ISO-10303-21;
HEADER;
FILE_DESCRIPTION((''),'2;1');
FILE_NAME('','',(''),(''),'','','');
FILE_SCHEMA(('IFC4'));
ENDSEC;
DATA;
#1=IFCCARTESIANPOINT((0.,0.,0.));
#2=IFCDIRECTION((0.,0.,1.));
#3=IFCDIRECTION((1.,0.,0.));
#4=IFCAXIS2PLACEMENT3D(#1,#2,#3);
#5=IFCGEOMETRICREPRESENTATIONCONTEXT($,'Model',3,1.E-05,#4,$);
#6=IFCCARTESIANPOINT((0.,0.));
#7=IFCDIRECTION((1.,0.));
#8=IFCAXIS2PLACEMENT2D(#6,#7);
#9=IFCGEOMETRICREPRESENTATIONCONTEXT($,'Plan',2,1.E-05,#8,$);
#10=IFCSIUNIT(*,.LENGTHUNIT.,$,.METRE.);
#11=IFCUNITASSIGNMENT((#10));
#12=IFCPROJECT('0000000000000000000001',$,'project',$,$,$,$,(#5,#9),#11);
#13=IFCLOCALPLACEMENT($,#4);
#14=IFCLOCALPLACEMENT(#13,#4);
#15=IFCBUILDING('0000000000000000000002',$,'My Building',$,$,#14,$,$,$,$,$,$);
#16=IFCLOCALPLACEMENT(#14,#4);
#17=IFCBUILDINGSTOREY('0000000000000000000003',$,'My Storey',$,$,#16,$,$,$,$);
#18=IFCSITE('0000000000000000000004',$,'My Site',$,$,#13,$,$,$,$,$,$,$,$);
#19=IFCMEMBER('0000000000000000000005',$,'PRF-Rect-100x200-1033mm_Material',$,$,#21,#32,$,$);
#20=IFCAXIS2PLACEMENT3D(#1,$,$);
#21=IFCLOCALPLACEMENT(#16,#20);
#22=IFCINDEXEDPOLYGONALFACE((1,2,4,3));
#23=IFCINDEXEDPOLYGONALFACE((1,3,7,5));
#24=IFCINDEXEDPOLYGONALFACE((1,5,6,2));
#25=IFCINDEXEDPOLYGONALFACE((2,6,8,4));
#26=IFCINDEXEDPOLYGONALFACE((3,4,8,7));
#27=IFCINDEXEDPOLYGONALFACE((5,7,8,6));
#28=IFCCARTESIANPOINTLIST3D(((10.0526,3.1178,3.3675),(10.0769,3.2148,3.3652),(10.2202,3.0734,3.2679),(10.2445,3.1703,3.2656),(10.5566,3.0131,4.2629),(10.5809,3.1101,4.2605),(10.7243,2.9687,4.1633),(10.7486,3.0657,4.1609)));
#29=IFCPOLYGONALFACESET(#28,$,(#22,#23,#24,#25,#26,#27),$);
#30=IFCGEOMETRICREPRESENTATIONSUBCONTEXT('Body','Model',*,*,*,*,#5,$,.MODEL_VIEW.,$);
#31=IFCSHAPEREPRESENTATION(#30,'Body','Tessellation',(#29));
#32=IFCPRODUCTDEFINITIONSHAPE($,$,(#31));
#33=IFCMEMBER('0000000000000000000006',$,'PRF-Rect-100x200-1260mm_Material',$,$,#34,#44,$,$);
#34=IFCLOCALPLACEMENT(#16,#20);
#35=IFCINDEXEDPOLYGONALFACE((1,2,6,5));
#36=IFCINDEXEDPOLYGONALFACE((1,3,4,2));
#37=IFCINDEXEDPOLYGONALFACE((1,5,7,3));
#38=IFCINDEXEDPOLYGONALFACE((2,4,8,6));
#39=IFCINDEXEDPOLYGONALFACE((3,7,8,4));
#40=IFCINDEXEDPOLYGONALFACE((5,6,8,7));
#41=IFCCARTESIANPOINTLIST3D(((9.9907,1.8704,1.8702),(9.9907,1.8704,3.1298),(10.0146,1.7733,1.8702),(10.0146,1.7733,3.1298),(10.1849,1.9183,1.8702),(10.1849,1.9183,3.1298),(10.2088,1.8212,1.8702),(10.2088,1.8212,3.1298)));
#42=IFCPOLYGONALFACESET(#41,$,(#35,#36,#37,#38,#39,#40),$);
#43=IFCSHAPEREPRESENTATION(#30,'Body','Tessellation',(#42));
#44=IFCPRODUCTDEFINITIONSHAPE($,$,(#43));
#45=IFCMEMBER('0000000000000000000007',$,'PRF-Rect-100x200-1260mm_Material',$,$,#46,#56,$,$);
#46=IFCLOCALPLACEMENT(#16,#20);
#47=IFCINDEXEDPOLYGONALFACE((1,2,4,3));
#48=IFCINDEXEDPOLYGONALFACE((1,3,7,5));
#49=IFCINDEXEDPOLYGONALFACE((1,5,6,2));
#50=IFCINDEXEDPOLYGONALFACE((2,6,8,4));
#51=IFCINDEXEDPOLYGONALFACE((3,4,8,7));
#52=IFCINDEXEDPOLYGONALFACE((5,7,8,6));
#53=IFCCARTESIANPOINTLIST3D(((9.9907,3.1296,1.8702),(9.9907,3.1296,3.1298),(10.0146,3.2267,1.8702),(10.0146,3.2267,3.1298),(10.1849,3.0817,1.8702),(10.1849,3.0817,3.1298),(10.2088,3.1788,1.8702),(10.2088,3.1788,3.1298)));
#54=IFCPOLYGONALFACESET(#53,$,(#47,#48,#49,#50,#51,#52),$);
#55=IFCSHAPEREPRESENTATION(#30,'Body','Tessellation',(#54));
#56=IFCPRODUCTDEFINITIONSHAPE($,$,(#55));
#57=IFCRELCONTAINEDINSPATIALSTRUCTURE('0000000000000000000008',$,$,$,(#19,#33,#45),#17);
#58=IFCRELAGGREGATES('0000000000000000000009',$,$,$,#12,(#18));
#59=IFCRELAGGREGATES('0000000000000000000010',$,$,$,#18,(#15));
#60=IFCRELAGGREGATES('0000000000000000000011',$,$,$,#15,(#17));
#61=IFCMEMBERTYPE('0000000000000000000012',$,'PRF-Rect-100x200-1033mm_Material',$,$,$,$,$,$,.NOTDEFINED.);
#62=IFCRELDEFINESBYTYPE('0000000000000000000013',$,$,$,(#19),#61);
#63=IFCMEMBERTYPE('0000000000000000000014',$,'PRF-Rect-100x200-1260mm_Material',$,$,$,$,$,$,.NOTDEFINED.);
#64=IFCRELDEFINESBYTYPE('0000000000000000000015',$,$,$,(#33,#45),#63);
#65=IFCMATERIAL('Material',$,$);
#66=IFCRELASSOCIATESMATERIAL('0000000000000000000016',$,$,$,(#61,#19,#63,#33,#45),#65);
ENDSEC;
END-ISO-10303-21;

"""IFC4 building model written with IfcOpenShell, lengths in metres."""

from ifc_helpers import new_model, si_unit, frame, origin, origin_with_axes, origin_2d_with_axis, place, context, subcontext, project, spatial, rectangle, extrude, material, material_profile, profile_set, profile_usage, type_object, element, save


model = new_model("IFC4")

# Units and contexts
model_context = context("Model", 3, precision=1e-05, world=origin_with_axes())
plan_context = context("Plan", 2, precision=1e-05, world=origin_2d_with_axis())
body_context = subcontext(model_context, "Body", "Model", "MODEL_VIEW")
ifc_project = project(units=[si_unit("LENGTHUNIT", "METRE")], contexts=[model_context, plan_context])

# Site, building, storey
site_placement = place(None, origin_with_axes())
site = spatial("IfcSite", under=ifc_project, at=site_placement, Name="My Site")
building_placement = place(site_placement, origin_with_axes())
building = spatial("IfcBuilding", under=site, at=building_placement, Name="My Building")
storey_placement = place(building_placement, origin_with_axes())
storey = spatial("IfcBuildingStorey", under=building, at=storey_placement, Name="My Storey")

# Members
ifc_material_1 = material(Name="Material")
ifc_material_profile_1 = material_profile(ifc_material_1, rectangle(XDim=0.1, YDim=0.2))
ifc_profile_set_1 = profile_set([ifc_material_profile_1], Name="PRF-Rect-100x200-1033mm_Material")
member_type_1 = type_object("IfcMemberType", Name="PRF-Rect-100x200-1033mm_Material", PredefinedType="NOTDEFINED", material=ifc_profile_set_1)
ifc_profile_usage_1 = profile_usage(ifc_profile_set_1, cardinal=5)
member_1_placement = place(storey_placement, frame((10.6526, 3.0394, 4.2119), z_axis=(-0.488039, 0.101315, -0.866922), x_axis=(-0.242978, -0.969748, 0.023454)))
element("IfcMember", 1, at=member_1_placement, inside=storey, type_object=member_type_1, material=ifc_profile_usage_1, Name="PRF-Rect-100x200-1033mm_Material", context=body_context, shape_type="SweptSolid", body=[
    extrude(rectangle(XDim=0.1, YDim=0.2), origin(), (0.0, 0.0, 1.0), 1.0328),
])
ifc_material_profile_2 = material_profile(ifc_material_1, rectangle(XDim=0.1, YDim=0.2))
ifc_profile_set_2 = profile_set([ifc_material_profile_2], Name="PRF-Rect-100x200-1260mm_Material")
ifc_profile_usage_2 = profile_usage(ifc_profile_set_2, cardinal=5)
member_type_2 = type_object("IfcMemberType", Name="PRF-Rect-100x200-1260mm_Material", PredefinedType="NOTDEFINED", material=ifc_profile_set_2)
member_2_placement = place(storey_placement, frame((10.0998, 1.8458, 3.1298), z_axis=(0.0, 0.0, -1.0), x_axis=(0.239658, -0.970857, 0.0)))
element("IfcMember", 2, at=member_2_placement, inside=storey, type_object=member_type_2, material=ifc_profile_usage_2, Name="PRF-Rect-100x200-1260mm_Material", context=body_context, shape_type="SweptSolid", body=[
    extrude(rectangle(XDim=0.1, YDim=0.2), origin(), (0.0, 0.0, 1.0), 1.2597),
])
ifc_profile_usage_3 = profile_usage(ifc_profile_set_2, cardinal=5)
member_3_placement = place(storey_placement, frame((10.0998, 3.1542, 3.1298), z_axis=(0.0, 0.0, -1.0), x_axis=(-0.239658, -0.970857, 0.0)))
element("IfcMember", 3, at=member_3_placement, inside=storey, type_object=member_type_2, material=ifc_profile_usage_3, Name="PRF-Rect-100x200-1260mm_Material", context=body_context, shape_type="SweptSolid", body=[
    extrude(rectangle(XDim=0.1, YDim=0.2), origin(), (0.0, 0.0, 1.0), 1.2597),
])

save(model, "model.ifc")
